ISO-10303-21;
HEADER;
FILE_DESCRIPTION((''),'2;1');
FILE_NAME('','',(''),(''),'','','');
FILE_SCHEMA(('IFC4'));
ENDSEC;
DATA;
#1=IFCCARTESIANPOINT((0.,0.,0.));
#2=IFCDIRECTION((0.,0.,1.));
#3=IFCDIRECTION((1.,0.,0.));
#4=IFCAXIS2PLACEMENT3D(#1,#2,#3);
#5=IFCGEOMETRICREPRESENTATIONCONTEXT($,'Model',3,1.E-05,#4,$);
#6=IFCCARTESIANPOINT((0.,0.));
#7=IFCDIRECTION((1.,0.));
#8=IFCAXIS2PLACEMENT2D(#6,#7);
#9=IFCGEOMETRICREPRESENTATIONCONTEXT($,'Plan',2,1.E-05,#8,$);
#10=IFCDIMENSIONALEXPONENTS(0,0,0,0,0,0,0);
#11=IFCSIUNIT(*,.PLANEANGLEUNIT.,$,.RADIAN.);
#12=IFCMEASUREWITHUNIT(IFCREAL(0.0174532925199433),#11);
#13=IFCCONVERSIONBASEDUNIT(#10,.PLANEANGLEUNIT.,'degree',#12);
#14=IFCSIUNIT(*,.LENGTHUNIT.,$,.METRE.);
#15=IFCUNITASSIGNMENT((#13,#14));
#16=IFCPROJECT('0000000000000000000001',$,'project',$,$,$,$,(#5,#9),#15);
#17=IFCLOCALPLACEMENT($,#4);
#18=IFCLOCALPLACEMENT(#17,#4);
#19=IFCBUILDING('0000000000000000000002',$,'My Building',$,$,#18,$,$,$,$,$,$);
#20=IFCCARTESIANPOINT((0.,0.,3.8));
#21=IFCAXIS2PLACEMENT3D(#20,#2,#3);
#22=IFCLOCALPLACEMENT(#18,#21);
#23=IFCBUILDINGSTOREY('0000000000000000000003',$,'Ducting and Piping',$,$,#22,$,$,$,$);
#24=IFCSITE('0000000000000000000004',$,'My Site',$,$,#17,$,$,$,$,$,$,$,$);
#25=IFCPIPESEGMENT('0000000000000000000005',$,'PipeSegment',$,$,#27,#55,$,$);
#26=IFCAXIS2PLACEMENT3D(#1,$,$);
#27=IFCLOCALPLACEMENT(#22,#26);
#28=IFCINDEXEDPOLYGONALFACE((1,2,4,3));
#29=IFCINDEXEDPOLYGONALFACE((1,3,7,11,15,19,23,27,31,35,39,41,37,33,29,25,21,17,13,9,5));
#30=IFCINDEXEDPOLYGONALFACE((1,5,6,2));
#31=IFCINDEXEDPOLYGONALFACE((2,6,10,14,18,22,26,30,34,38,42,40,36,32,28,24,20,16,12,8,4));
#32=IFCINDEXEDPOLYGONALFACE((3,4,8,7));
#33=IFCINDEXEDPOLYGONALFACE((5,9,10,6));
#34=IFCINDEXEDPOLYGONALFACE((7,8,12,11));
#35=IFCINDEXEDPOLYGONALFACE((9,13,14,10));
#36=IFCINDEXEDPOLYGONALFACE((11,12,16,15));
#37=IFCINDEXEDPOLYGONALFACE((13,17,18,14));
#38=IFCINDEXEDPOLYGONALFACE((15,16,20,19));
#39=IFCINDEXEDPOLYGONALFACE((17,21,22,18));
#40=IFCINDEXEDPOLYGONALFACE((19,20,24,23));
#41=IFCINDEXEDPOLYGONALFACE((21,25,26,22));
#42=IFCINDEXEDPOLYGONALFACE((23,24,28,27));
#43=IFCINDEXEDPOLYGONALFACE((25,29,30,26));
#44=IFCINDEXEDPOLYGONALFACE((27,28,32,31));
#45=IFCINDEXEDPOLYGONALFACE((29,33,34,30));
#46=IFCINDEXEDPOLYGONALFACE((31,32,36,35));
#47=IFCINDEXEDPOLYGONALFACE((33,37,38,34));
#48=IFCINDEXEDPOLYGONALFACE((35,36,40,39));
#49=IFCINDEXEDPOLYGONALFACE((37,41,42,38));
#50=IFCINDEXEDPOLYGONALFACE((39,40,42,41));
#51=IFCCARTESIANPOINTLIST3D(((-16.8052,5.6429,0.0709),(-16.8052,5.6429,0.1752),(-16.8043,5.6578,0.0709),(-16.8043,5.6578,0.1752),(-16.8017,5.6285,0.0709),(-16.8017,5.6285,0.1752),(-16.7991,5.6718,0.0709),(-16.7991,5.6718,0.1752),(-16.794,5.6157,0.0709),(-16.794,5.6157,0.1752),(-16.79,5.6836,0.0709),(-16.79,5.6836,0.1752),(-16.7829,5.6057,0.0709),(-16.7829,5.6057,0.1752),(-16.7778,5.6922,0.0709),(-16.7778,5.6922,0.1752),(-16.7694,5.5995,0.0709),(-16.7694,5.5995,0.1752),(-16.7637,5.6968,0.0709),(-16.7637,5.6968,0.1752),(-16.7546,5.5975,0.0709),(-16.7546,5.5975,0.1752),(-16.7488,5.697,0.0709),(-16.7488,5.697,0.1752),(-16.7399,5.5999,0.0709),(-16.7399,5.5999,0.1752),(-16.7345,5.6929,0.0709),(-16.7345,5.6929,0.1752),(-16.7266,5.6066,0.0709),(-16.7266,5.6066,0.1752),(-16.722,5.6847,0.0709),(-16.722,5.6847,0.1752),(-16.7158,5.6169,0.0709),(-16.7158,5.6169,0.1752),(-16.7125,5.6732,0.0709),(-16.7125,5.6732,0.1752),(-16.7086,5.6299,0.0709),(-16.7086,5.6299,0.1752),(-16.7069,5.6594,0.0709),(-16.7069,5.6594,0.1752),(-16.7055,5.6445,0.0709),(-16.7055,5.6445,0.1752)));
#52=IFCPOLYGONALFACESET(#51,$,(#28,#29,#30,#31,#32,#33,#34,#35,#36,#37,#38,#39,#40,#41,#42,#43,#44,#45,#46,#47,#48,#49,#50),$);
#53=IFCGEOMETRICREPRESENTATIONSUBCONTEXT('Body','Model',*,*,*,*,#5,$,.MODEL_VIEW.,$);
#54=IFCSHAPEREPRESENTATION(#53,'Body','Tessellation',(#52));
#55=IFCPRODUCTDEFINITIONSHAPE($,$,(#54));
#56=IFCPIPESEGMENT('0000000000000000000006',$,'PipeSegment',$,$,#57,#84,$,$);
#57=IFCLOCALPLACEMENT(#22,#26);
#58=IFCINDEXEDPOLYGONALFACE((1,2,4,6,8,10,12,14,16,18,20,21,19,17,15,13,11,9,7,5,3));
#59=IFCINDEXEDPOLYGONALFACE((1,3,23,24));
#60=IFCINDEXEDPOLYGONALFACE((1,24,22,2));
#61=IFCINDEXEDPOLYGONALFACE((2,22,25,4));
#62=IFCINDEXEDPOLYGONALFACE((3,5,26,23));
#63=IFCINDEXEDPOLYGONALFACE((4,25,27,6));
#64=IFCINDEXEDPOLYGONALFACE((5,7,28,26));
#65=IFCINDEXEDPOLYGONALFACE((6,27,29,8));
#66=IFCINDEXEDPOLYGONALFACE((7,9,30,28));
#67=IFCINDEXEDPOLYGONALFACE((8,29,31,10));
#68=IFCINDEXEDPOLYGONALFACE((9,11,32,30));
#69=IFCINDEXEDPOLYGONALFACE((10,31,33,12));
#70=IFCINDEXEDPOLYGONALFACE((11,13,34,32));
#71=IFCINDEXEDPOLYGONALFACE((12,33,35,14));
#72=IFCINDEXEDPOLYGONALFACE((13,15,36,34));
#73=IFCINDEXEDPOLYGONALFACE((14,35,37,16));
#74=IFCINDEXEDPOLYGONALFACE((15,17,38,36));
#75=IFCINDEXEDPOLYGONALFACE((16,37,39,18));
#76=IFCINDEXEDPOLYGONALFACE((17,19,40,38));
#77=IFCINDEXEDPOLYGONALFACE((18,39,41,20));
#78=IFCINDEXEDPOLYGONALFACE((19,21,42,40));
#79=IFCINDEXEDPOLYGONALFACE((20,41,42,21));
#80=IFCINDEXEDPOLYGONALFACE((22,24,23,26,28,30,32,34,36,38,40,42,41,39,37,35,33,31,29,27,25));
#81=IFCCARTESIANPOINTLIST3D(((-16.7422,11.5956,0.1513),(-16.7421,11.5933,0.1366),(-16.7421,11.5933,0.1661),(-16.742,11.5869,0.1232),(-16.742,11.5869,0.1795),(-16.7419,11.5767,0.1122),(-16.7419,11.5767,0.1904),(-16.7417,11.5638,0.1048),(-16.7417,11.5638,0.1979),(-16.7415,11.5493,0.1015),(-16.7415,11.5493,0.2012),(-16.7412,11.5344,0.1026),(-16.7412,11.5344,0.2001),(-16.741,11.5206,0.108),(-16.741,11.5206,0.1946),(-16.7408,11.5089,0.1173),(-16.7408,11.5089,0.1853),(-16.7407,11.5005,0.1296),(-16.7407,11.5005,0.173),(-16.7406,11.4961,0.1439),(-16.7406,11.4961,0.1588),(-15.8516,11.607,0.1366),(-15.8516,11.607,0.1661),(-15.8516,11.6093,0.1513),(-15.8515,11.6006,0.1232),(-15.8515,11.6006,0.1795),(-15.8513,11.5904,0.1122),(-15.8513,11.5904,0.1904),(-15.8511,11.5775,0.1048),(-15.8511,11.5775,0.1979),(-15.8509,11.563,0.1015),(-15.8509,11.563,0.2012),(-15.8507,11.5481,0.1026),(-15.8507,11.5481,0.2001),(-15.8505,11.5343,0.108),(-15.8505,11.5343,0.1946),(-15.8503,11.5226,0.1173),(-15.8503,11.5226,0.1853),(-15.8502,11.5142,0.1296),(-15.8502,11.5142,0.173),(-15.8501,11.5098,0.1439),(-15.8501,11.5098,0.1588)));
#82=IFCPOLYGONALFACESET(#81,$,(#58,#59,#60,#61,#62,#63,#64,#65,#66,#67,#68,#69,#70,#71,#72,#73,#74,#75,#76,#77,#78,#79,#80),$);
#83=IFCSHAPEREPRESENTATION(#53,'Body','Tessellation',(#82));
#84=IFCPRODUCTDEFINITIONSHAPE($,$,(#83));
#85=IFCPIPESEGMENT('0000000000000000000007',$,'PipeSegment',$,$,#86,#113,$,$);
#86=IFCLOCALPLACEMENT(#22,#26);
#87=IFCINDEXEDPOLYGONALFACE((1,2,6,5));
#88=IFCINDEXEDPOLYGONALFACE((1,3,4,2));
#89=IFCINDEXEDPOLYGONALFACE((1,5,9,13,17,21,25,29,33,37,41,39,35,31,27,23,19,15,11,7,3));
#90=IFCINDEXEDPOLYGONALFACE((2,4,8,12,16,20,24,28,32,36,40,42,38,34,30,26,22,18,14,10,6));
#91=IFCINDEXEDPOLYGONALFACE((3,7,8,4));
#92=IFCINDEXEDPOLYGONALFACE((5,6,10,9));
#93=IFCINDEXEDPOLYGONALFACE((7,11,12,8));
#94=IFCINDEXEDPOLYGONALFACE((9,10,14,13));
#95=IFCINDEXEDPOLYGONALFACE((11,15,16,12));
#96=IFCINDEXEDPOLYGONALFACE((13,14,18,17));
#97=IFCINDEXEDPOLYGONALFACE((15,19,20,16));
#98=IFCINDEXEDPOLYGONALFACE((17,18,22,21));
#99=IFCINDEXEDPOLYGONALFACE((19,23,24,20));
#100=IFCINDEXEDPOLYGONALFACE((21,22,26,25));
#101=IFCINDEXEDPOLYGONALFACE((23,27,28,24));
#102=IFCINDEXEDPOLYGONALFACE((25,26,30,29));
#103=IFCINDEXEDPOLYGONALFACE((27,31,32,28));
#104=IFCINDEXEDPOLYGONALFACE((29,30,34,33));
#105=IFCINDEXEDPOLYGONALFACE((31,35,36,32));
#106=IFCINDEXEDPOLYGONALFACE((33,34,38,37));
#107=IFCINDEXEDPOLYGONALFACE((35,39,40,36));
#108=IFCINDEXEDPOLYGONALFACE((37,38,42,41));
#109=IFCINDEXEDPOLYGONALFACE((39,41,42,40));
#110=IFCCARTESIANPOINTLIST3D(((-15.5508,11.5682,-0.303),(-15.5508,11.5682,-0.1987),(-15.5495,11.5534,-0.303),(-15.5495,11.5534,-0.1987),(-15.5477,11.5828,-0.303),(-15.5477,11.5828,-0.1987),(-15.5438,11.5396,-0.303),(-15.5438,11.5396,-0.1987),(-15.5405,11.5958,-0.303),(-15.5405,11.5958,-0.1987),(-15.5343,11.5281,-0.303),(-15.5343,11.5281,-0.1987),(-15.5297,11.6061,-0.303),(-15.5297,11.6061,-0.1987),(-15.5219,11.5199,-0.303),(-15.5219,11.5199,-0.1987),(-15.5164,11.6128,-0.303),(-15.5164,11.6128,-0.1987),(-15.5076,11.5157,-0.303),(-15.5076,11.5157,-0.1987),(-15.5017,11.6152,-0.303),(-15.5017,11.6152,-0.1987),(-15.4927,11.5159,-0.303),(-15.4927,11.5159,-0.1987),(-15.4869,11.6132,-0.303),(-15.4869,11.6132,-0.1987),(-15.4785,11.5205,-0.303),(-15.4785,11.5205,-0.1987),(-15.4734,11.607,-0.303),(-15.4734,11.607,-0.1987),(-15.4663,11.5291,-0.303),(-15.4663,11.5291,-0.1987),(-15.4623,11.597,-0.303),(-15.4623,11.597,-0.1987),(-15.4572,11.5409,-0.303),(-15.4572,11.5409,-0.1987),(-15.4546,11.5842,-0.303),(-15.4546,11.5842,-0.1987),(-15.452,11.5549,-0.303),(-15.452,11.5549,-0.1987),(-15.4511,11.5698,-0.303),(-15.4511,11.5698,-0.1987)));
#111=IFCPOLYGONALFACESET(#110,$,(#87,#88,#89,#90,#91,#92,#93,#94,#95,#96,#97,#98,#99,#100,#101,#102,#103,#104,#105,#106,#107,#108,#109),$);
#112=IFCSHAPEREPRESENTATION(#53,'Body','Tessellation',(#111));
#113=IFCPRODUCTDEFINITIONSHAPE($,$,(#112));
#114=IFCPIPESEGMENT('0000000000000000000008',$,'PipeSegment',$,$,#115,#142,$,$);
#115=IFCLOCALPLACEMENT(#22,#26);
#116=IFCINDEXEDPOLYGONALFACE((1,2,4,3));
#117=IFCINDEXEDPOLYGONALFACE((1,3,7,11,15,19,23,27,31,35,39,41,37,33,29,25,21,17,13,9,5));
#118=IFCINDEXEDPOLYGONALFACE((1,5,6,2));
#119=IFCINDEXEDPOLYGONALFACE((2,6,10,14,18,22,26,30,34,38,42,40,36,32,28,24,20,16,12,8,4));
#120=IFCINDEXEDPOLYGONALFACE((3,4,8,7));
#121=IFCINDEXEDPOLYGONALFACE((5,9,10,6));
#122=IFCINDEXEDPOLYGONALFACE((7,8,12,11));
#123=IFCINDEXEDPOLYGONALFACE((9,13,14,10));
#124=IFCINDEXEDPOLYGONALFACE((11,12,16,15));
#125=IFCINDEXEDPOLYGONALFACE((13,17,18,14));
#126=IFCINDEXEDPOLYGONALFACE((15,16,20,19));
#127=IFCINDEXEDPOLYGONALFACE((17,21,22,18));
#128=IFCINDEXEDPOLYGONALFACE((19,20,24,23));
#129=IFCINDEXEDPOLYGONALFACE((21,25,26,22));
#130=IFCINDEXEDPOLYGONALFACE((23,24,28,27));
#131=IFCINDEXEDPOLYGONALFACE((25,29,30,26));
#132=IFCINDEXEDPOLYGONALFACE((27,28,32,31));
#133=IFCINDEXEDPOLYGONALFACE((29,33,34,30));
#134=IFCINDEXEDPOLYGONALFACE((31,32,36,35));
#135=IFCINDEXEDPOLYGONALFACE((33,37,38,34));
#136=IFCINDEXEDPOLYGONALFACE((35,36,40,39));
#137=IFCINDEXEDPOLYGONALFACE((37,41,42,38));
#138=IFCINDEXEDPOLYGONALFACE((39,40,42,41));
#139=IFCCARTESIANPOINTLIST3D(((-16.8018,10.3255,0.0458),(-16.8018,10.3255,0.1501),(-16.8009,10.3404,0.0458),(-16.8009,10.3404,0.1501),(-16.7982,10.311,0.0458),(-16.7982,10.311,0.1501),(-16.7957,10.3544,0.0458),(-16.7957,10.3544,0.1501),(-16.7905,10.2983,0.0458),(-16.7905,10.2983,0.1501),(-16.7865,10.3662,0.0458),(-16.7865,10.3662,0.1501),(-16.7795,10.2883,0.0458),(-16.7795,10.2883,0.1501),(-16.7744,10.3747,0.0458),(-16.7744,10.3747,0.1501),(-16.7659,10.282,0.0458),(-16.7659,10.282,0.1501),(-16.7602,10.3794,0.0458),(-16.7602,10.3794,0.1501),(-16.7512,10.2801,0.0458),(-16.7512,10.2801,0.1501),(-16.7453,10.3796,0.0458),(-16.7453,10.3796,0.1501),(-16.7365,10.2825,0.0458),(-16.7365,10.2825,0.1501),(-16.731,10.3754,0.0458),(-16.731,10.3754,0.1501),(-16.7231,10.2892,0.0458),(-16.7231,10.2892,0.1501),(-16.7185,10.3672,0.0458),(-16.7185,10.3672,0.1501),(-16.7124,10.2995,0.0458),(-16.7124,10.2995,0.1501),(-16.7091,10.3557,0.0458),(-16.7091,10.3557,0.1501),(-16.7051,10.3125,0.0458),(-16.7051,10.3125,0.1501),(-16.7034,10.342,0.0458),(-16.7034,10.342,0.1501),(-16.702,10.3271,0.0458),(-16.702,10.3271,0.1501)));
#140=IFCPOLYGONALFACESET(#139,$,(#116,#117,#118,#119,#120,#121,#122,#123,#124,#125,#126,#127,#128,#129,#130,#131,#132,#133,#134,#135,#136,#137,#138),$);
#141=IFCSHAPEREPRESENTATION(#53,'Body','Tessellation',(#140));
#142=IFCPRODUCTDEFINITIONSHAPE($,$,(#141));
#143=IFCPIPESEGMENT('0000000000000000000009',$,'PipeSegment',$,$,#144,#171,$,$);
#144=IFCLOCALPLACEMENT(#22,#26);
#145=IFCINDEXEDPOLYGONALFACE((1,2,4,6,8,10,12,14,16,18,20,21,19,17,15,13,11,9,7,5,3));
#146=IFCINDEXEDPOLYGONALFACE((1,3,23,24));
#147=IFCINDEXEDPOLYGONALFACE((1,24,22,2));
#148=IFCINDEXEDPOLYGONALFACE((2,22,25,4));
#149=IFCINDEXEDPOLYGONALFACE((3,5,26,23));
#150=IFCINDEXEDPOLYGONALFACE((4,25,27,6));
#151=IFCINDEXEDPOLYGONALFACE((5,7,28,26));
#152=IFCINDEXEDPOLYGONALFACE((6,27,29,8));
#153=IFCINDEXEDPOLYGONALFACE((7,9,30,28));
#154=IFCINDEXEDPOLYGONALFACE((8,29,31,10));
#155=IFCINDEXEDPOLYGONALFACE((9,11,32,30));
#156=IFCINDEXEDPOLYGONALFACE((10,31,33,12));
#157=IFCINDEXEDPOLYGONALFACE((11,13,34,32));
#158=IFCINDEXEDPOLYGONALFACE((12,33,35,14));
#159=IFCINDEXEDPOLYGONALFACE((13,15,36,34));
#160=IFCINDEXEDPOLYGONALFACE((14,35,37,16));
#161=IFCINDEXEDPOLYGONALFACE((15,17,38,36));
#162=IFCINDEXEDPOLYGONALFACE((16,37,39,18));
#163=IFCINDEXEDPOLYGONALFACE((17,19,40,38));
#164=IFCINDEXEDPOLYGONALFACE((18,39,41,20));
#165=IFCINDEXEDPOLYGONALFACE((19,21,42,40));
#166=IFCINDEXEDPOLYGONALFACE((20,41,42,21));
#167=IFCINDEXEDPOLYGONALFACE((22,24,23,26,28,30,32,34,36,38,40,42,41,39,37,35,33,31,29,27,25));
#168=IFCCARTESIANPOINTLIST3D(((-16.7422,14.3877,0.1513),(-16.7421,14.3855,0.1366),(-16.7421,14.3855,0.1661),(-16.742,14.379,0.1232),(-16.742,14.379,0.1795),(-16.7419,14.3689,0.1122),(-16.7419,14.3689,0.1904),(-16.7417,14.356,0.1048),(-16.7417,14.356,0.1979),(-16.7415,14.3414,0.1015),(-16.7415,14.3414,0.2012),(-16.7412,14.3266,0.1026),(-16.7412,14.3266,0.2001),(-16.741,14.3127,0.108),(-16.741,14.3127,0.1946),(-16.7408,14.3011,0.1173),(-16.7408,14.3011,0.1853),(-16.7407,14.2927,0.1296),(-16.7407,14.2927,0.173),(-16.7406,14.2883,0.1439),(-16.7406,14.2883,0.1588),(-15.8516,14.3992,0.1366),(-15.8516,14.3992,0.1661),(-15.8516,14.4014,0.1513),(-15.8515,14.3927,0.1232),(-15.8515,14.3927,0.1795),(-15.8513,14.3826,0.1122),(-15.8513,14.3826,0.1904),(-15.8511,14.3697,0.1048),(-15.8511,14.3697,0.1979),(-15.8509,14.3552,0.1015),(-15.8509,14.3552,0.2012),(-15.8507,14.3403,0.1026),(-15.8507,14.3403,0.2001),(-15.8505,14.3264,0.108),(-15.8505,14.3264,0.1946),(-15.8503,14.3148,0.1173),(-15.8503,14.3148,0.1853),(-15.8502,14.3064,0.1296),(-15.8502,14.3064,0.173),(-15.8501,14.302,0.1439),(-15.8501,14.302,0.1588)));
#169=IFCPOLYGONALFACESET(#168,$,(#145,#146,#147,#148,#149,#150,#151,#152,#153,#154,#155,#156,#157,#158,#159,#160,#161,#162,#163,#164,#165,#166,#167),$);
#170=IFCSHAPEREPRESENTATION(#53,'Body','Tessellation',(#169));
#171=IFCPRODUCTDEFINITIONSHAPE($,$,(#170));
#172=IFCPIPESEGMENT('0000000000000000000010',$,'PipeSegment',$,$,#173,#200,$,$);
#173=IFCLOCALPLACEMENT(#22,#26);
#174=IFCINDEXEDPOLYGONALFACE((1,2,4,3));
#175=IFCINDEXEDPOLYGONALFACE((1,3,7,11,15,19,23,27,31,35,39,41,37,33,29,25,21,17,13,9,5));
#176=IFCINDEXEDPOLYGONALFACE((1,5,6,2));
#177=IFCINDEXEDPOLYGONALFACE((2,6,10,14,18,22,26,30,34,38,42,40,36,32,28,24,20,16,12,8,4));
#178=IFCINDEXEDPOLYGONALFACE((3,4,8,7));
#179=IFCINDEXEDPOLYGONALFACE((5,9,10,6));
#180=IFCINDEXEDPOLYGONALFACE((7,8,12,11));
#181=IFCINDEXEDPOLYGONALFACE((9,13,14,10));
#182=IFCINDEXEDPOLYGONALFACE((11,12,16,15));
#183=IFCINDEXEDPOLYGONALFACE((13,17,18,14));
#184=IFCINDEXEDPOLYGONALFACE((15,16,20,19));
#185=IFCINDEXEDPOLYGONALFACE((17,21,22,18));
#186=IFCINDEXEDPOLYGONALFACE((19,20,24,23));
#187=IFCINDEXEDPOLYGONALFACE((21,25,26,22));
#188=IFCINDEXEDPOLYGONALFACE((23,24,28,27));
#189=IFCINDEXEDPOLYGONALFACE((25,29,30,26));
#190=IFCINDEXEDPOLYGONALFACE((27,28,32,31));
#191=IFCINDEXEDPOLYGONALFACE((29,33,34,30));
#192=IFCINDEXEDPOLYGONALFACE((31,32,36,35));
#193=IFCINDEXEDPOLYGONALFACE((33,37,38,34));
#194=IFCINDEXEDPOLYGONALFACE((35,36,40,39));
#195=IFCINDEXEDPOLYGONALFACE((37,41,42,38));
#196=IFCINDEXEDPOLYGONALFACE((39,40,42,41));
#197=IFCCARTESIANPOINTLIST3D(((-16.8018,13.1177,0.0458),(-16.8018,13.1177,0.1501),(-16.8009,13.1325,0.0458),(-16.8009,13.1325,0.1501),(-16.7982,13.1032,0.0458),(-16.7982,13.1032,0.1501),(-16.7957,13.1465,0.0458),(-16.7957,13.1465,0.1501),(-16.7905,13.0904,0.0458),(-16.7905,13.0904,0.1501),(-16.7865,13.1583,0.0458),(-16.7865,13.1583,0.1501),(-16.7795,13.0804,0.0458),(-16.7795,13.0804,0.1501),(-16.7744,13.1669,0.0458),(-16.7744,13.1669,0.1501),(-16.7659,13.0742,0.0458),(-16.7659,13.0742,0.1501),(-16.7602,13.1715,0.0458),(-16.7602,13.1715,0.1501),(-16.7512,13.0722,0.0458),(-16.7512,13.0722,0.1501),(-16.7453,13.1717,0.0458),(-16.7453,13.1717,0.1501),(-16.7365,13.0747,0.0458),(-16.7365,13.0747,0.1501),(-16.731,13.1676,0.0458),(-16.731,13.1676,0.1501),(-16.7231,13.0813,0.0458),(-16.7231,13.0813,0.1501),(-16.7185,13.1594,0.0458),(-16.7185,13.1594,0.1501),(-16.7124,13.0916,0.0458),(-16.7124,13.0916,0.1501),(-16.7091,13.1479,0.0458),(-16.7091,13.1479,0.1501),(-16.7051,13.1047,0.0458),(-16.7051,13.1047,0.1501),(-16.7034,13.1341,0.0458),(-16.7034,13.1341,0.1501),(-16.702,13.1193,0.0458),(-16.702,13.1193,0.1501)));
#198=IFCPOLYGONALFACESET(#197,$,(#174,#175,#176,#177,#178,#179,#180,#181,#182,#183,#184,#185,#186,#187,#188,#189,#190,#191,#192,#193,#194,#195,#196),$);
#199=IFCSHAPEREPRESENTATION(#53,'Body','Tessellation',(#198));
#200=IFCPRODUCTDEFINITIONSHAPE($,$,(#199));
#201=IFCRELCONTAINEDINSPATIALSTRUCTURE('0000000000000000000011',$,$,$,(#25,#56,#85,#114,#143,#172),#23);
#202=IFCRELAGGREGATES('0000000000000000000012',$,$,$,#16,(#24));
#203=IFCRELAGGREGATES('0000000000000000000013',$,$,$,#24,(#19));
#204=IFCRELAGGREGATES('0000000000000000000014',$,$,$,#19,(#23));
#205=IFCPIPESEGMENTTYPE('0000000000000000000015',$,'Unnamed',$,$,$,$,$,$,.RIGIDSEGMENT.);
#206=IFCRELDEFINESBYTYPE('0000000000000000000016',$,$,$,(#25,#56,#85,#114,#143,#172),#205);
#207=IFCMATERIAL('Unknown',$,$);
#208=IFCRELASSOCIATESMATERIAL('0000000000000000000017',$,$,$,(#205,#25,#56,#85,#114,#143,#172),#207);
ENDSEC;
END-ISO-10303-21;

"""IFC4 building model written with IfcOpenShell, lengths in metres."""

from ifc_helpers import new_model, entity, si_unit, converted_unit, frame, origin_with_axes, origin_2d_with_axis, place, context, subcontext, project, spatial, circle, extrude, material, material_profile, profile_set, profile_usage, type_object, element, save


model = new_model("IFC4")

# Units and contexts
model_context = context("Model", 3, precision=1e-05, world=origin_with_axes())
plan_context = context("Plan", 2, precision=1e-05, world=origin_2d_with_axis())
body_context = subcontext(model_context, "Body", "Model", "MODEL_VIEW")
ifc_project = project(units=[converted_unit("PLANEANGLEUNIT", "degree", entity("IfcReal", 0.0174532925199433), si_unit("PLANEANGLEUNIT", "RADIAN"), dimensions=[0, 0, 0, 0, 0, 0, 0]), si_unit("LENGTHUNIT", "METRE")], contexts=[model_context, plan_context])

# Site, building, storey
site_placement = place(None, origin_with_axes())
site = spatial("IfcSite", under=ifc_project, at=site_placement, Name="My Site")
building_placement = place(site_placement, origin_with_axes())
building = spatial("IfcBuilding", under=site, at=building_placement, Name="My Building")
storey_placement = place(building_placement, frame((0.0, 0.0, 3.8), z_axis=(0.0, 0.0, 1.0), x_axis=(1.0, 0.0, 0.0)))
storey = spatial("IfcBuildingStorey", under=building, at=storey_placement, Name="Ducting and Piping")

# Pipe segments
ifc_material = material(Name="Unknown")
ifc_material_profile_1 = material_profile(ifc_material, circle(Radius=0.05))
ifc_profile_set_1 = profile_set([ifc_material_profile_1])
pipe_segment_type = type_object("IfcPipeSegmentType", Name="Unnamed", PredefinedType="RIGIDSEGMENT", material=ifc_profile_set_1)
ifc_profile_usage_1 = profile_usage(ifc_profile_set_1, cardinal=5)
pipe_segment_1_placement = place(storey_placement, frame((-16.7554, 5.6475, 0.0709), z_axis=(0.0, 0.0, 1.0), x_axis=(0.015928, -0.999873, 0.0)))
element("IfcPipeSegment", 1, at=pipe_segment_1_placement, inside=storey, type_object=pipe_segment_type, material=ifc_profile_usage_1, Name="PipeSegment", context=body_context, shape_type="SweptSolid", body=[
    extrude(circle(Radius=0.05), origin_with_axes(), (0.0, 0.0, 1.0), 0.1043),
])
ifc_profile_usage_2 = profile_usage(ifc_profile_set_1, cardinal=5)
pipe_segment_2_placement = place(storey_placement, frame((-16.7414, 11.5456, 0.1513), z_axis=(0.999882, 0.015389, 0.0), x_axis=(-0.015389, 0.999882, 0.0)))
element("IfcPipeSegment", 2, at=pipe_segment_2_placement, inside=storey, type_object=pipe_segment_type, material=ifc_profile_usage_2, Name="PipeSegment", context=body_context, shape_type="SweptSolid", body=[
    extrude(circle(Radius=0.05), origin_with_axes(), (0.0, 0.0, 1.0), 0.8907),
])
ifc_profile_usage_3 = profile_usage(ifc_profile_set_1, cardinal=5)
pipe_segment_3_placement = place(storey_placement, frame((-15.5009, 11.5652, -0.303), z_axis=(0.0, 0.0, 1.0), x_axis=(-0.015371, 0.999882, 0.0)))
element("IfcPipeSegment", 3, at=pipe_segment_3_placement, inside=storey, type_object=pipe_segment_type, material=ifc_profile_usage_3, Name="PipeSegment", context=body_context, shape_type="SweptSolid", body=[
    extrude(circle(Radius=0.05), origin_with_axes(), (0.0, 0.0, 1.0), 0.1043),
])
ifc_profile_usage_4 = profile_usage(ifc_profile_set_1, cardinal=5)
pipe_segment_4_placement = place(storey_placement, frame((-16.752, 10.33, 0.0458), z_axis=(0.0, 0.0, 1.0), x_axis=(0.015928, -0.999873, 0.0)))
element("IfcPipeSegment", 4, at=pipe_segment_4_placement, inside=storey, type_object=pipe_segment_type, material=ifc_profile_usage_4, Name="PipeSegment", context=body_context, shape_type="SweptSolid", body=[
    extrude(circle(Radius=0.05), origin_with_axes(), (0.0, 0.0, 1.0), 0.1043),
])
ifc_profile_usage_5 = profile_usage(ifc_profile_set_1, cardinal=5)
pipe_segment_5_placement = place(storey_placement, frame((-16.7414, 14.3377, 0.1513), z_axis=(0.999882, 0.015389, 0.0), x_axis=(-0.015389, 0.999882, 0.0)))
element("IfcPipeSegment", 5, at=pipe_segment_5_placement, inside=storey, type_object=pipe_segment_type, material=ifc_profile_usage_5, Name="PipeSegment", context=body_context, shape_type="SweptSolid", body=[
    extrude(circle(Radius=0.05), origin_with_axes(), (0.0, 0.0, 1.0), 0.8907),
])
ifc_profile_usage_6 = profile_usage(ifc_profile_set_1, cardinal=5)
pipe_segment_6_placement = place(storey_placement, frame((-16.752, 13.1222, 0.0458), z_axis=(0.0, 0.0, 1.0), x_axis=(0.015928, -0.999873, 0.0)))
element("IfcPipeSegment", 6, at=pipe_segment_6_placement, inside=storey, type_object=pipe_segment_type, material=ifc_profile_usage_6, Name="PipeSegment", context=body_context, shape_type="SweptSolid", body=[
    extrude(circle(Radius=0.05), origin_with_axes(), (0.0, 0.0, 1.0), 0.1043),
])

save(model, "model.ifc")
